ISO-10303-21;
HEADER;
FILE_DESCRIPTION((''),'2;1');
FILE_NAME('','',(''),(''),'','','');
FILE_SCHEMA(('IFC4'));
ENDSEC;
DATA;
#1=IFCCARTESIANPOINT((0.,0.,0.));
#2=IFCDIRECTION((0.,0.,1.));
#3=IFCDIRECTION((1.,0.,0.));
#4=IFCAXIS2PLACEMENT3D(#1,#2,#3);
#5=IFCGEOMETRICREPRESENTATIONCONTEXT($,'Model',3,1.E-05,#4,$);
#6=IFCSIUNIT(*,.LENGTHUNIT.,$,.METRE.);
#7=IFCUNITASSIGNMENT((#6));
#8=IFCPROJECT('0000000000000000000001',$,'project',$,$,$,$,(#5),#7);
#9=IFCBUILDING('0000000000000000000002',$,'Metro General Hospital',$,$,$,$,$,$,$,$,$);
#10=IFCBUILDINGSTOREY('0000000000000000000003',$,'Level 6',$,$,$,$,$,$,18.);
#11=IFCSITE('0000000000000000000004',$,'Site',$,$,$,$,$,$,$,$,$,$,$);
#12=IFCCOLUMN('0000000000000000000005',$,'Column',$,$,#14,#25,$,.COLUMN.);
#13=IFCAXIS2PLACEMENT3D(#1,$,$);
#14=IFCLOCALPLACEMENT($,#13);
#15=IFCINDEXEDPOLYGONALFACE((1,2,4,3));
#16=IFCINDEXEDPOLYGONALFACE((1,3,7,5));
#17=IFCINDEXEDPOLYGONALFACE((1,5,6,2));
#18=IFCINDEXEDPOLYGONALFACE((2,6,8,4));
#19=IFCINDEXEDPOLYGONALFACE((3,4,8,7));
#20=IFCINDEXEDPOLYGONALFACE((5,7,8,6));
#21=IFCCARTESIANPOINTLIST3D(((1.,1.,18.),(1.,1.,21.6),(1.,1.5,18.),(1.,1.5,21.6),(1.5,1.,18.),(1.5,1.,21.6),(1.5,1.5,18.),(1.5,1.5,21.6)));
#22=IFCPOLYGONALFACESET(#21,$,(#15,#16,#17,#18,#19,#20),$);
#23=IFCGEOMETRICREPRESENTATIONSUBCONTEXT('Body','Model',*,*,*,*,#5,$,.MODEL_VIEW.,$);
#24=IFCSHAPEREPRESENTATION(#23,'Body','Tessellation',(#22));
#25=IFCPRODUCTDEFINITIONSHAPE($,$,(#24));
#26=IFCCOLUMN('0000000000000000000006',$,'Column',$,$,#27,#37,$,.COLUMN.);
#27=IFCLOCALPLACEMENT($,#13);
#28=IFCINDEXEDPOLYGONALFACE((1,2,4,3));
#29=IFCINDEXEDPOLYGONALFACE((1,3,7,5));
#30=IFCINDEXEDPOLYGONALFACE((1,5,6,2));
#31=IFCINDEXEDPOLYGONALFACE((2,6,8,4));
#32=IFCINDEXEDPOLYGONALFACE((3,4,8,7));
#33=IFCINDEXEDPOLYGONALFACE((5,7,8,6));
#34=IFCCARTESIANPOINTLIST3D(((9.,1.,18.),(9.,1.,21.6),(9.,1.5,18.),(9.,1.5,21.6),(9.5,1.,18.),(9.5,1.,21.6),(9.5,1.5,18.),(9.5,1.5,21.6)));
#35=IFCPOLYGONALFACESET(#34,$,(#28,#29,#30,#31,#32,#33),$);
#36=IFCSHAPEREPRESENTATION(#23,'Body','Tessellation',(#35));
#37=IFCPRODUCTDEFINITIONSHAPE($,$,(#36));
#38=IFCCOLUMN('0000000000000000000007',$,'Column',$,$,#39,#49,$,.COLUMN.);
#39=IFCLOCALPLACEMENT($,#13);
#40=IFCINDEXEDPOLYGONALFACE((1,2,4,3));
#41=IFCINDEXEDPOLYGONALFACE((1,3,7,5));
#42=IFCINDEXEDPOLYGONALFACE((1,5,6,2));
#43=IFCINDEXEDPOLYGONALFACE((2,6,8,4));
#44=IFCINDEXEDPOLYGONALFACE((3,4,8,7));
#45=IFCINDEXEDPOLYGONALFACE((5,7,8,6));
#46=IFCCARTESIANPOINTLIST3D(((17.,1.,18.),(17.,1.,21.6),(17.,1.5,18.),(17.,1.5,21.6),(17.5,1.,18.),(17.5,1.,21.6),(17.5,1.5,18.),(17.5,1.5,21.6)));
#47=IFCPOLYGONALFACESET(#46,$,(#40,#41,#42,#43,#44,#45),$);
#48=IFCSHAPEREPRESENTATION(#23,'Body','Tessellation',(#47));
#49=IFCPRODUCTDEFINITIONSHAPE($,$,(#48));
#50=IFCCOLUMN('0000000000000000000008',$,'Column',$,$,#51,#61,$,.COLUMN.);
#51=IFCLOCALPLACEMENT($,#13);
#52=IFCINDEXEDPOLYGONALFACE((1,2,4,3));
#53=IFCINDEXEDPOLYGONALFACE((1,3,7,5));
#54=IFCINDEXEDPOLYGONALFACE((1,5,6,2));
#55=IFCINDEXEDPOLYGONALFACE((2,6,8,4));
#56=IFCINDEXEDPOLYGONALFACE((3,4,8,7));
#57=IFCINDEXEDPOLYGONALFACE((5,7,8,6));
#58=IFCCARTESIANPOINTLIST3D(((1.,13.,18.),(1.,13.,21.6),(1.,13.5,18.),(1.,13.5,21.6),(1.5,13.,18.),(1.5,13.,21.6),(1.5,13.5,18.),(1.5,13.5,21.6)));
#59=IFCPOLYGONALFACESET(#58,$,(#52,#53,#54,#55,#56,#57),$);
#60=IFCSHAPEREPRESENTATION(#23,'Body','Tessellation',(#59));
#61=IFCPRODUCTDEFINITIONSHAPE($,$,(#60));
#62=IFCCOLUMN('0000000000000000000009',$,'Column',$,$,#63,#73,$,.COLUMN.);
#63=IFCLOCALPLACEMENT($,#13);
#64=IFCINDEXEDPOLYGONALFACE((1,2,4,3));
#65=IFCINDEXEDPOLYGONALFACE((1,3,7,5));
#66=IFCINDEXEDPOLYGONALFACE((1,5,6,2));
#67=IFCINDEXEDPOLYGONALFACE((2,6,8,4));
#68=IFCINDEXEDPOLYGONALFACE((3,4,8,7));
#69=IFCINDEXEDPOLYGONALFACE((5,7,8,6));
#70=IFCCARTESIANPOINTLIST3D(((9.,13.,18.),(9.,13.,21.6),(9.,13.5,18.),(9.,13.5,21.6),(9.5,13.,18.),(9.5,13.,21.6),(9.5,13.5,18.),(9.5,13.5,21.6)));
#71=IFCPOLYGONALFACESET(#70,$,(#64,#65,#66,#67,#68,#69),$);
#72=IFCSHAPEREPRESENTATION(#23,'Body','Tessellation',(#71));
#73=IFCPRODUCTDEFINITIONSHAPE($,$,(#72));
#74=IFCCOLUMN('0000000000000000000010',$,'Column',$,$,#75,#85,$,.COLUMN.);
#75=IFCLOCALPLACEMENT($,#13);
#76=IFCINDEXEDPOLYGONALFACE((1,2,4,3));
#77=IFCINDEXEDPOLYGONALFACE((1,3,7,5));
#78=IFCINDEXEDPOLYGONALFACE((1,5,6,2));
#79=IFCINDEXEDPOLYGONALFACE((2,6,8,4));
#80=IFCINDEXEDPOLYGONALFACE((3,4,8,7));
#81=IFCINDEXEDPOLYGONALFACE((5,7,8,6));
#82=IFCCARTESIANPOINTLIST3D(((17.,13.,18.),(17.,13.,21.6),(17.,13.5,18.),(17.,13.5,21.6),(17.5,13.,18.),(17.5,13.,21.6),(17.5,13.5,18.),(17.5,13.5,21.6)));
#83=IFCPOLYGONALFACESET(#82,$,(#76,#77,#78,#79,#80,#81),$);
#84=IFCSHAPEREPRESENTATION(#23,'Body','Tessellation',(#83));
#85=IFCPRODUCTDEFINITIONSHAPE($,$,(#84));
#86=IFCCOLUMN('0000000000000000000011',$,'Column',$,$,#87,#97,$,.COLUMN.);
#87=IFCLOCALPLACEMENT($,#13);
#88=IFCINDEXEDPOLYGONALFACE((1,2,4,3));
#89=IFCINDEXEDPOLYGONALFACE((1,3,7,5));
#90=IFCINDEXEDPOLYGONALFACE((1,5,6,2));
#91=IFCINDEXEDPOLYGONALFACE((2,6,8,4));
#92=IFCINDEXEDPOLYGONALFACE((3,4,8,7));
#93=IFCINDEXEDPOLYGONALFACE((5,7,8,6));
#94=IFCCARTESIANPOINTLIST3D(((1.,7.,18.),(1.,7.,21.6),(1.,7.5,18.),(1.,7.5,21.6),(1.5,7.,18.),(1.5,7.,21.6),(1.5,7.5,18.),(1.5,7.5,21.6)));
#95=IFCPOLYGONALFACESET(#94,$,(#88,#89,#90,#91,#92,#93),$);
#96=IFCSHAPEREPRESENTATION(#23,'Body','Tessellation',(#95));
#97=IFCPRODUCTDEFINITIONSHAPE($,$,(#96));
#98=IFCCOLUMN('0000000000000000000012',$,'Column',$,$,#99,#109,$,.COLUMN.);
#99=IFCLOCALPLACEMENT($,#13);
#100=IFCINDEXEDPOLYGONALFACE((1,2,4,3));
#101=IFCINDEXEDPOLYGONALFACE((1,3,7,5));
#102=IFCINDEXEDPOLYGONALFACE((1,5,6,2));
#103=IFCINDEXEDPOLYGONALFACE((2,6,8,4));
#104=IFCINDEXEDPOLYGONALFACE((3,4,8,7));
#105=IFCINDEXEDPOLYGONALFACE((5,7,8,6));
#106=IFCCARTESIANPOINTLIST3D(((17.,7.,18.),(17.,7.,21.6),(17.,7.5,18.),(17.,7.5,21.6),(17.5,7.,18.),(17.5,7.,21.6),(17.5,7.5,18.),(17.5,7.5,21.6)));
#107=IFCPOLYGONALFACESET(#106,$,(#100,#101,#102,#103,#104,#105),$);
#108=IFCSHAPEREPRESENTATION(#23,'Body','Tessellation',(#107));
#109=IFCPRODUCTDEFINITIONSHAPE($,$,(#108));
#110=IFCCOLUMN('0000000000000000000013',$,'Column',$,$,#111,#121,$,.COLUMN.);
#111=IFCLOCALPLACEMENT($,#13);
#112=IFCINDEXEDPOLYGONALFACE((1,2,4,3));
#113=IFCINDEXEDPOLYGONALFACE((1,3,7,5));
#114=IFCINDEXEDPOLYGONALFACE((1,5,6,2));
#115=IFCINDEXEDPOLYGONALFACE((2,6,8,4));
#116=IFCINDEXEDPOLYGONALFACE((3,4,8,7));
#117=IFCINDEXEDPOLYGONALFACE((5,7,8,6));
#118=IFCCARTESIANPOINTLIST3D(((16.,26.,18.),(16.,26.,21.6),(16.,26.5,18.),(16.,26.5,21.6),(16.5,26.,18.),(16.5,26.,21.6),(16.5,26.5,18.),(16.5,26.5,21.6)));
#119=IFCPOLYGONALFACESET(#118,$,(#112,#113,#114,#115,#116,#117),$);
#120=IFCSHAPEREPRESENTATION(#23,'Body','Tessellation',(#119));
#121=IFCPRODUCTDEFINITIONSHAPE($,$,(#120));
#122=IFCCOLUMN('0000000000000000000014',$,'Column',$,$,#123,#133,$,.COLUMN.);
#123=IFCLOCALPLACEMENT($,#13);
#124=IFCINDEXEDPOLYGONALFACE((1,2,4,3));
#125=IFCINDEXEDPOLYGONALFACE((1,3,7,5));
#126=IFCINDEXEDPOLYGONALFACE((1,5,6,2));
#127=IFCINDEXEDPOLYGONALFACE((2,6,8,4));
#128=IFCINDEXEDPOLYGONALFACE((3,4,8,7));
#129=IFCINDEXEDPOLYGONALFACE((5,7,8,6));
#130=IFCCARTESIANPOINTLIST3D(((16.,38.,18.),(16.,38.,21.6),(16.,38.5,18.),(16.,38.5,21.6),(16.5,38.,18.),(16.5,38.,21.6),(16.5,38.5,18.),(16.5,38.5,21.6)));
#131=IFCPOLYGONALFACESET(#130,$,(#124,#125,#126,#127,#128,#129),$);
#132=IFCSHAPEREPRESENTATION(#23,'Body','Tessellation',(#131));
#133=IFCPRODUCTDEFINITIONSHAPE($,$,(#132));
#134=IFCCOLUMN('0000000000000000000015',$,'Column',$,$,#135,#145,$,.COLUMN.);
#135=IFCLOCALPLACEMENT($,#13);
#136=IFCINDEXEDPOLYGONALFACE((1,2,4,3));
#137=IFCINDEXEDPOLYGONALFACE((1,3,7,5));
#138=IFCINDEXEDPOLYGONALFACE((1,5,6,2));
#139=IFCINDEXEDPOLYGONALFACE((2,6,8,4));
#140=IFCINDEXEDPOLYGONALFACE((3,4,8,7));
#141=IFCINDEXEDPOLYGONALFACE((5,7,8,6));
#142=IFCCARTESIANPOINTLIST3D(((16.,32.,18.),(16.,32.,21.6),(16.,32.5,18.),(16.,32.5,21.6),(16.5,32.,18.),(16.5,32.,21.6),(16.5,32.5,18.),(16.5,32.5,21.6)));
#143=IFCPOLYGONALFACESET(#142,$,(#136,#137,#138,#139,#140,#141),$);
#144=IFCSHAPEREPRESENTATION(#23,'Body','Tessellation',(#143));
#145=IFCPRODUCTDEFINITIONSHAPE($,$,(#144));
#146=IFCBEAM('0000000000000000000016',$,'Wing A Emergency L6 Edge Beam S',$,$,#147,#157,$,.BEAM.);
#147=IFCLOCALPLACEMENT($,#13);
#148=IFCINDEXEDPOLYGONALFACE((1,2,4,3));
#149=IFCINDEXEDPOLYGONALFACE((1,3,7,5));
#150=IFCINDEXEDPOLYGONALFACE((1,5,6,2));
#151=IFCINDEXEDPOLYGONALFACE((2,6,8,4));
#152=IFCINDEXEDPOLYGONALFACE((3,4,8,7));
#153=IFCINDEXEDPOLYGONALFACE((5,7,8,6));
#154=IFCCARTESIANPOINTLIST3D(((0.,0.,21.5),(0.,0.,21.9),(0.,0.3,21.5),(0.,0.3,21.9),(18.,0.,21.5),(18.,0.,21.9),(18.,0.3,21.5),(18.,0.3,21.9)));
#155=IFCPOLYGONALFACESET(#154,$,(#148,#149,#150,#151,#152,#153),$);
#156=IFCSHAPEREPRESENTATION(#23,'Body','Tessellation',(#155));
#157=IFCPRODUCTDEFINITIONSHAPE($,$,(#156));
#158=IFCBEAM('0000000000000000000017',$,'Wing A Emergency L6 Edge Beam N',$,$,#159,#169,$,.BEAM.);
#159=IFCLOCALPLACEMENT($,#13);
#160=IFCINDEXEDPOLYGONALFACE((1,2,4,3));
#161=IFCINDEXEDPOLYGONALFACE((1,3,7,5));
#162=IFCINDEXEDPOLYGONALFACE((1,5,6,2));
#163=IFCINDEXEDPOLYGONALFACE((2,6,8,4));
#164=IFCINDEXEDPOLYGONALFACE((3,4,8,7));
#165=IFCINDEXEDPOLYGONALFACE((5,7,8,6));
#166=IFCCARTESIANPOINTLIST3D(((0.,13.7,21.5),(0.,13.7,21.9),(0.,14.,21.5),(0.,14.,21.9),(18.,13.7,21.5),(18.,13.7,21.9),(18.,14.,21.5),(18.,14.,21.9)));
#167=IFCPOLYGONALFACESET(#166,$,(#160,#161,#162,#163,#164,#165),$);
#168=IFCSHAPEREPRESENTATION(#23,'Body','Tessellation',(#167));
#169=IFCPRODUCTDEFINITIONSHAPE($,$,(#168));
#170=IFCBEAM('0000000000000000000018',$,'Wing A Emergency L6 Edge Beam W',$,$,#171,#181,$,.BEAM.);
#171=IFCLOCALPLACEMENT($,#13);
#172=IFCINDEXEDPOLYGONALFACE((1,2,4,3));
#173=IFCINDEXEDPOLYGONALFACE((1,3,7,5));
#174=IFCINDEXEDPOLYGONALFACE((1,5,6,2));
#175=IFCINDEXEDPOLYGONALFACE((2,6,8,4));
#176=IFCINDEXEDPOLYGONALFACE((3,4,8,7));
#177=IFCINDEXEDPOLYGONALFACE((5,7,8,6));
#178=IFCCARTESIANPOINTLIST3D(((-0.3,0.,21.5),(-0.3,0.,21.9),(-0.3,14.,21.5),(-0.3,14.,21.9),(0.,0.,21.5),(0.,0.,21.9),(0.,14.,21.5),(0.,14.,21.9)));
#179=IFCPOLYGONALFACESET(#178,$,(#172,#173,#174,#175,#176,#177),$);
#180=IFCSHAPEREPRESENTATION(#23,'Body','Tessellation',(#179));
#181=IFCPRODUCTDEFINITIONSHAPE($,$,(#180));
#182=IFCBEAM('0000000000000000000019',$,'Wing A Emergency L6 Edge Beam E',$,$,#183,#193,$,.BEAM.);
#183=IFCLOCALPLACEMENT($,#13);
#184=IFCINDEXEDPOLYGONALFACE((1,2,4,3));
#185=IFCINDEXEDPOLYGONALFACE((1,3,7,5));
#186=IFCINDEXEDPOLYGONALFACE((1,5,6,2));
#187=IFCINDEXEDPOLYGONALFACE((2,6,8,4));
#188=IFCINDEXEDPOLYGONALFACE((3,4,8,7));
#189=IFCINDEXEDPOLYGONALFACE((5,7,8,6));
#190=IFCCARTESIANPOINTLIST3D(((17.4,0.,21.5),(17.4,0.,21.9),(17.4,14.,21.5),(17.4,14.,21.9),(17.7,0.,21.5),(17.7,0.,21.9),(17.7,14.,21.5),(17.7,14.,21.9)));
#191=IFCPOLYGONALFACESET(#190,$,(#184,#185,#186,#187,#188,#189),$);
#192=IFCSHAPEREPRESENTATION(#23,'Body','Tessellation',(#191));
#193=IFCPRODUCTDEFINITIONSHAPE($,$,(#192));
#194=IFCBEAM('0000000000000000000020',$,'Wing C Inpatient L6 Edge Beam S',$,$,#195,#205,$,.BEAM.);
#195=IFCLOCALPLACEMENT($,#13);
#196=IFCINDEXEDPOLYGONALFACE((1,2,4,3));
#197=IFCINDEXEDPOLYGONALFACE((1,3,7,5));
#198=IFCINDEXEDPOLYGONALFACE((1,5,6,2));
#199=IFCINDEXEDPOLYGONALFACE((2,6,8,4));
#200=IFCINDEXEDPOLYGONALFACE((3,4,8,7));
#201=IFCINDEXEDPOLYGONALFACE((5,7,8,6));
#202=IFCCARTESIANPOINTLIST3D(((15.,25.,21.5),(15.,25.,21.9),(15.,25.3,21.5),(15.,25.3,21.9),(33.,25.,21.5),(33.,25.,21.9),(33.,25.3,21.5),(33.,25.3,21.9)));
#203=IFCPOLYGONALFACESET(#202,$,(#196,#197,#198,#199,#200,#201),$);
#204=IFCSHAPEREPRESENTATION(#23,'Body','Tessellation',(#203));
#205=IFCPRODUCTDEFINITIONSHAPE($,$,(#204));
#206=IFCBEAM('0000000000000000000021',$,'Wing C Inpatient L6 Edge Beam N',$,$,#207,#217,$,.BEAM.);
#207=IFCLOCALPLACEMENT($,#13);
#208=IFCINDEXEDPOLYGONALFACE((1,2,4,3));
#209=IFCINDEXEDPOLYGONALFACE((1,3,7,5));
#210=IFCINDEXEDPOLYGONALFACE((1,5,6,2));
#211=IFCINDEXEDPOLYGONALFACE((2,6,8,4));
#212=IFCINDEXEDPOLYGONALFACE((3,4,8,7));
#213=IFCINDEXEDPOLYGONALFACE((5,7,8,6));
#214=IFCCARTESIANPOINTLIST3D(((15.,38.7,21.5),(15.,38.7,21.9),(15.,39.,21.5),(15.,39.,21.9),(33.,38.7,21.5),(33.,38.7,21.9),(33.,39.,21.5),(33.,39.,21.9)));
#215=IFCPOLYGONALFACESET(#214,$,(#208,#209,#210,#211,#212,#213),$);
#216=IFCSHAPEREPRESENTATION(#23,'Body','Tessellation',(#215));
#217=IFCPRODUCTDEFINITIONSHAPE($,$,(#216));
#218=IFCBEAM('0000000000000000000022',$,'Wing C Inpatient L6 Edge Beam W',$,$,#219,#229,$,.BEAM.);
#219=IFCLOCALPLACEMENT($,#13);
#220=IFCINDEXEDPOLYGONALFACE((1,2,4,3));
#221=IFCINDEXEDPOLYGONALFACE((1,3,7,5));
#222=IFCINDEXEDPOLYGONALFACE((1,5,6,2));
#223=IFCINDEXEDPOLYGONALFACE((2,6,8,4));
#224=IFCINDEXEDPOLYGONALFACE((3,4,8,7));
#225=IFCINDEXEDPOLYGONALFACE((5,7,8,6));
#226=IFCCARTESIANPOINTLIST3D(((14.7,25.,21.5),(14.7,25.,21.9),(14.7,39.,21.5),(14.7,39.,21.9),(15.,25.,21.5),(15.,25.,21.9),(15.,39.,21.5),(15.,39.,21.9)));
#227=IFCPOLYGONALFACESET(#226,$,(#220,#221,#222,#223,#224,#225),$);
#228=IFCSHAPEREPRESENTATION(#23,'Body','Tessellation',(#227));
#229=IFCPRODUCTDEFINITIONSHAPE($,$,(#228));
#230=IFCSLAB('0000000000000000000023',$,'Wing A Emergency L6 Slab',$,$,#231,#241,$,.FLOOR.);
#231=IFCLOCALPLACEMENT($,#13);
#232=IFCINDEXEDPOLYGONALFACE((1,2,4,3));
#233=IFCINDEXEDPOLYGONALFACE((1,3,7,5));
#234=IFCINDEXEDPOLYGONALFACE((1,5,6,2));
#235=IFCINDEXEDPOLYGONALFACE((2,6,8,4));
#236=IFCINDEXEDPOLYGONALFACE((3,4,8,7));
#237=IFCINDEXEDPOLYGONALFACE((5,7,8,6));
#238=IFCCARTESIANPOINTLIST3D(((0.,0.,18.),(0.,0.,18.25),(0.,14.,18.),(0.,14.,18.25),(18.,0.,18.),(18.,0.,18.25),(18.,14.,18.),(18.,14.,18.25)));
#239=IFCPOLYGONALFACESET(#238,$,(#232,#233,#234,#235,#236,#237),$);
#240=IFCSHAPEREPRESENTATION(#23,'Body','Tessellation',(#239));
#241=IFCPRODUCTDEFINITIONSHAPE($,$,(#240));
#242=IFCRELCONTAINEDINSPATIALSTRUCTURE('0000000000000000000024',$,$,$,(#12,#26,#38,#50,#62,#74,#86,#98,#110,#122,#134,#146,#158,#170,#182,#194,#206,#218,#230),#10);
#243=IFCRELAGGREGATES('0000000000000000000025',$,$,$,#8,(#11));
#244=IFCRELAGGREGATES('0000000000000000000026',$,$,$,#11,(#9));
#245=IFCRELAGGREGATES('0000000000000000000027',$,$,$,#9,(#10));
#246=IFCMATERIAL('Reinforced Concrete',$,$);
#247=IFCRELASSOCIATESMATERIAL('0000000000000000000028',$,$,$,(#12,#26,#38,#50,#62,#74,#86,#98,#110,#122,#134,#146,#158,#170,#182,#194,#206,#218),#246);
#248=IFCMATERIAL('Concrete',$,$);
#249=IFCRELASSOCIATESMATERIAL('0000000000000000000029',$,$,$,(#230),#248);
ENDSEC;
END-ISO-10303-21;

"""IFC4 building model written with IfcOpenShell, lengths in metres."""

from ifc_helpers import new_model, si_unit, frame, origin_with_axes, place, context, subcontext, project, spatial, line, indexed_curve, outline, extrude, material, element, save


model = new_model("IFC4")

# Units and contexts
model_context = context("Model", 3, precision=1e-05, world=origin_with_axes())
body_context = subcontext(model_context, "Body", "Model", "MODEL_VIEW")
ifc_project = project(units=[si_unit("LENGTHUNIT", "METRE")], contexts=[model_context])

# Site, building, storey
site = spatial("IfcSite", under=ifc_project, Name="Site")
building = spatial("IfcBuilding", under=site, Name="Metro General Hospital")
storey = spatial("IfcBuildingStorey", under=building, Name="Level 6", Elevation=18.0)

# Columns
ifc_material_1 = material(Name="Reinforced Concrete")
for number, where, z_axis, x_axis, name in (
    (1, (1.0, 1.0, 18.0), (0.0, 0.0, 1.0), (1.0, 0.0, 0.0), "Column"),
    (2, (9.0, 1.0, 18.0), (0.0, 0.0, 1.0), (1.0, 0.0, 0.0), "Column"),
    (3, (17.0, 1.0, 18.0), (0.0, 0.0, 1.0), (1.0, 0.0, 0.0), "Column"),
    (4, (1.0, 13.0, 18.0), (0.0, 0.0, 1.0), (1.0, 0.0, 0.0), "Column"),
    (5, (9.0, 13.0, 18.0), (0.0, 0.0, 1.0), (1.0, 0.0, 0.0), "Column"),
    (6, (17.0, 13.0, 18.0), (0.0, 0.0, 1.0), (1.0, 0.0, 0.0), "Column"),
    (7, (1.0, 7.0, 18.0), (0.0, 0.0, 1.0), (1.0, 0.0, 0.0), "Column"),
    (8, (17.0, 7.0, 18.0), (0.0, 0.0, 1.0), (1.0, 0.0, 0.0), "Column"),
    (9, (16.0, 26.0, 18.0), (0.0, 0.0, 1.0), (1.0, 0.0, 0.0), "Column"),
    (10, (16.0, 38.0, 18.0), (0.0, 0.0, 1.0), (1.0, 0.0, 0.0), "Column"),
    (11, (16.0, 32.0, 18.0), (0.0, 0.0, 1.0), (1.0, 0.0, 0.0), "Column"),
):
    element("IfcColumn", number, at=place(None, frame(where, z_axis=z_axis, x_axis=x_axis)), inside=storey, material=ifc_material_1, Name=name, PredefinedType="COLUMN", context=body_context, shape_type="SweptSolid", body=[
        extrude(outline(indexed_curve([(0.0, 0.0), (0.5, 0.0), (0.5, 0.5), (0.0, 0.5)], segments=[line(1, 2, 3, 4, 1)])), origin_with_axes(), (0.0, 0.0, 1.0), 3.6),
    ])

# Beams
for number, where, z_axis, x_axis, name in (
    (12, (0.0, 0.0, 21.5), (0.0, 0.0, 1.0), (1.0, 0.0, 0.0), "Wing A Emergency L6 Edge Beam S"),
    (13, (0.0, 13.7, 21.5), (0.0, 0.0, 1.0), (1.0, 0.0, 0.0), "Wing A Emergency L6 Edge Beam N"),
):
    element("IfcBeam", number, at=place(None, frame(where, z_axis=z_axis, x_axis=x_axis)), inside=storey, material=ifc_material_1, Name=name, PredefinedType="BEAM", context=body_context, shape_type="SweptSolid", body=[
        extrude(outline(indexed_curve([(0.0, 0.0), (18.0, 0.0), (18.0, 0.3), (0.0, 0.3)], segments=[line(1, 2, 3, 4, 1)])), origin_with_axes(), (0.0, 0.0, 1.0), 0.4),
    ])
for number, where, z_axis, x_axis, name in (
    (14, (0.0, 0.0, 21.5), (0.0, 0.0, 1.0), (0.0, 1.0, 0.0), "Wing A Emergency L6 Edge Beam W"),
    (15, (17.7, 0.0, 21.5), (0.0, 0.0, 1.0), (0.0, 1.0, 0.0), "Wing A Emergency L6 Edge Beam E"),
):
    element("IfcBeam", number, at=place(None, frame(where, z_axis=z_axis, x_axis=x_axis)), inside=storey, material=ifc_material_1, Name=name, PredefinedType="BEAM", context=body_context, shape_type="SweptSolid", body=[
        extrude(outline(indexed_curve([(0.0, 0.0), (14.0, 0.0), (14.0, 0.3), (0.0, 0.3)], segments=[line(1, 2, 3, 4, 1)])), origin_with_axes(), (0.0, 0.0, 1.0), 0.4),
    ])
for number, where, z_axis, x_axis, name in (
    (16, (15.0, 25.0, 21.5), (0.0, 0.0, 1.0), (1.0, 0.0, 0.0), "Wing C Inpatient L6 Edge Beam S"),
    (17, (15.0, 38.7, 21.5), (0.0, 0.0, 1.0), (1.0, 0.0, 0.0), "Wing C Inpatient L6 Edge Beam N"),
):
    element("IfcBeam", number, at=place(None, frame(where, z_axis=z_axis, x_axis=x_axis)), inside=storey, material=ifc_material_1, Name=name, PredefinedType="BEAM", context=body_context, shape_type="SweptSolid", body=[
        extrude(outline(indexed_curve([(0.0, 0.0), (18.0, 0.0), (18.0, 0.3), (0.0, 0.3)], segments=[line(1, 2, 3, 4, 1)])), origin_with_axes(), (0.0, 0.0, 1.0), 0.4),
    ])
beam_placement = place(None, frame((15.0, 25.0, 21.5), z_axis=(0.0, 0.0, 1.0), x_axis=(0.0, 1.0, 0.0)))
element("IfcBeam", 18, at=beam_placement, inside=storey, material=ifc_material_1, Name="Wing C Inpatient L6 Edge Beam W", PredefinedType="BEAM", context=body_context, shape_type="SweptSolid", body=[
    extrude(outline(indexed_curve([(0.0, 0.0), (14.0, 0.0), (14.0, 0.3), (0.0, 0.3)], segments=[line(1, 2, 3, 4, 1)])), origin_with_axes(), (0.0, 0.0, 1.0), 0.4),
])

# Slab
ifc_material_2 = material(Name="Concrete")
for number, where, z_axis, x_axis, name in (
    (19, (0.0, 0.0, 18.0), (0.0, 0.0, 1.0), (1.0, 0.0, 0.0), "Wing A Emergency L6 Slab"),
):
    element("IfcSlab", number, at=place(None, frame(where, z_axis=z_axis, x_axis=x_axis)), inside=storey, material=ifc_material_2, Name=name, PredefinedType="FLOOR", context=body_context, shape_type="SweptSolid", body=[
        extrude(outline(indexed_curve([(0.0, 0.0), (18.0, 0.0), (18.0, 14.0), (0.0, 14.0)], segments=[line(1, 2, 3, 4, 1)])), origin_with_axes(), (0.0, 0.0, 1.0), 0.25),
    ])

save(model, "model.ifc")
